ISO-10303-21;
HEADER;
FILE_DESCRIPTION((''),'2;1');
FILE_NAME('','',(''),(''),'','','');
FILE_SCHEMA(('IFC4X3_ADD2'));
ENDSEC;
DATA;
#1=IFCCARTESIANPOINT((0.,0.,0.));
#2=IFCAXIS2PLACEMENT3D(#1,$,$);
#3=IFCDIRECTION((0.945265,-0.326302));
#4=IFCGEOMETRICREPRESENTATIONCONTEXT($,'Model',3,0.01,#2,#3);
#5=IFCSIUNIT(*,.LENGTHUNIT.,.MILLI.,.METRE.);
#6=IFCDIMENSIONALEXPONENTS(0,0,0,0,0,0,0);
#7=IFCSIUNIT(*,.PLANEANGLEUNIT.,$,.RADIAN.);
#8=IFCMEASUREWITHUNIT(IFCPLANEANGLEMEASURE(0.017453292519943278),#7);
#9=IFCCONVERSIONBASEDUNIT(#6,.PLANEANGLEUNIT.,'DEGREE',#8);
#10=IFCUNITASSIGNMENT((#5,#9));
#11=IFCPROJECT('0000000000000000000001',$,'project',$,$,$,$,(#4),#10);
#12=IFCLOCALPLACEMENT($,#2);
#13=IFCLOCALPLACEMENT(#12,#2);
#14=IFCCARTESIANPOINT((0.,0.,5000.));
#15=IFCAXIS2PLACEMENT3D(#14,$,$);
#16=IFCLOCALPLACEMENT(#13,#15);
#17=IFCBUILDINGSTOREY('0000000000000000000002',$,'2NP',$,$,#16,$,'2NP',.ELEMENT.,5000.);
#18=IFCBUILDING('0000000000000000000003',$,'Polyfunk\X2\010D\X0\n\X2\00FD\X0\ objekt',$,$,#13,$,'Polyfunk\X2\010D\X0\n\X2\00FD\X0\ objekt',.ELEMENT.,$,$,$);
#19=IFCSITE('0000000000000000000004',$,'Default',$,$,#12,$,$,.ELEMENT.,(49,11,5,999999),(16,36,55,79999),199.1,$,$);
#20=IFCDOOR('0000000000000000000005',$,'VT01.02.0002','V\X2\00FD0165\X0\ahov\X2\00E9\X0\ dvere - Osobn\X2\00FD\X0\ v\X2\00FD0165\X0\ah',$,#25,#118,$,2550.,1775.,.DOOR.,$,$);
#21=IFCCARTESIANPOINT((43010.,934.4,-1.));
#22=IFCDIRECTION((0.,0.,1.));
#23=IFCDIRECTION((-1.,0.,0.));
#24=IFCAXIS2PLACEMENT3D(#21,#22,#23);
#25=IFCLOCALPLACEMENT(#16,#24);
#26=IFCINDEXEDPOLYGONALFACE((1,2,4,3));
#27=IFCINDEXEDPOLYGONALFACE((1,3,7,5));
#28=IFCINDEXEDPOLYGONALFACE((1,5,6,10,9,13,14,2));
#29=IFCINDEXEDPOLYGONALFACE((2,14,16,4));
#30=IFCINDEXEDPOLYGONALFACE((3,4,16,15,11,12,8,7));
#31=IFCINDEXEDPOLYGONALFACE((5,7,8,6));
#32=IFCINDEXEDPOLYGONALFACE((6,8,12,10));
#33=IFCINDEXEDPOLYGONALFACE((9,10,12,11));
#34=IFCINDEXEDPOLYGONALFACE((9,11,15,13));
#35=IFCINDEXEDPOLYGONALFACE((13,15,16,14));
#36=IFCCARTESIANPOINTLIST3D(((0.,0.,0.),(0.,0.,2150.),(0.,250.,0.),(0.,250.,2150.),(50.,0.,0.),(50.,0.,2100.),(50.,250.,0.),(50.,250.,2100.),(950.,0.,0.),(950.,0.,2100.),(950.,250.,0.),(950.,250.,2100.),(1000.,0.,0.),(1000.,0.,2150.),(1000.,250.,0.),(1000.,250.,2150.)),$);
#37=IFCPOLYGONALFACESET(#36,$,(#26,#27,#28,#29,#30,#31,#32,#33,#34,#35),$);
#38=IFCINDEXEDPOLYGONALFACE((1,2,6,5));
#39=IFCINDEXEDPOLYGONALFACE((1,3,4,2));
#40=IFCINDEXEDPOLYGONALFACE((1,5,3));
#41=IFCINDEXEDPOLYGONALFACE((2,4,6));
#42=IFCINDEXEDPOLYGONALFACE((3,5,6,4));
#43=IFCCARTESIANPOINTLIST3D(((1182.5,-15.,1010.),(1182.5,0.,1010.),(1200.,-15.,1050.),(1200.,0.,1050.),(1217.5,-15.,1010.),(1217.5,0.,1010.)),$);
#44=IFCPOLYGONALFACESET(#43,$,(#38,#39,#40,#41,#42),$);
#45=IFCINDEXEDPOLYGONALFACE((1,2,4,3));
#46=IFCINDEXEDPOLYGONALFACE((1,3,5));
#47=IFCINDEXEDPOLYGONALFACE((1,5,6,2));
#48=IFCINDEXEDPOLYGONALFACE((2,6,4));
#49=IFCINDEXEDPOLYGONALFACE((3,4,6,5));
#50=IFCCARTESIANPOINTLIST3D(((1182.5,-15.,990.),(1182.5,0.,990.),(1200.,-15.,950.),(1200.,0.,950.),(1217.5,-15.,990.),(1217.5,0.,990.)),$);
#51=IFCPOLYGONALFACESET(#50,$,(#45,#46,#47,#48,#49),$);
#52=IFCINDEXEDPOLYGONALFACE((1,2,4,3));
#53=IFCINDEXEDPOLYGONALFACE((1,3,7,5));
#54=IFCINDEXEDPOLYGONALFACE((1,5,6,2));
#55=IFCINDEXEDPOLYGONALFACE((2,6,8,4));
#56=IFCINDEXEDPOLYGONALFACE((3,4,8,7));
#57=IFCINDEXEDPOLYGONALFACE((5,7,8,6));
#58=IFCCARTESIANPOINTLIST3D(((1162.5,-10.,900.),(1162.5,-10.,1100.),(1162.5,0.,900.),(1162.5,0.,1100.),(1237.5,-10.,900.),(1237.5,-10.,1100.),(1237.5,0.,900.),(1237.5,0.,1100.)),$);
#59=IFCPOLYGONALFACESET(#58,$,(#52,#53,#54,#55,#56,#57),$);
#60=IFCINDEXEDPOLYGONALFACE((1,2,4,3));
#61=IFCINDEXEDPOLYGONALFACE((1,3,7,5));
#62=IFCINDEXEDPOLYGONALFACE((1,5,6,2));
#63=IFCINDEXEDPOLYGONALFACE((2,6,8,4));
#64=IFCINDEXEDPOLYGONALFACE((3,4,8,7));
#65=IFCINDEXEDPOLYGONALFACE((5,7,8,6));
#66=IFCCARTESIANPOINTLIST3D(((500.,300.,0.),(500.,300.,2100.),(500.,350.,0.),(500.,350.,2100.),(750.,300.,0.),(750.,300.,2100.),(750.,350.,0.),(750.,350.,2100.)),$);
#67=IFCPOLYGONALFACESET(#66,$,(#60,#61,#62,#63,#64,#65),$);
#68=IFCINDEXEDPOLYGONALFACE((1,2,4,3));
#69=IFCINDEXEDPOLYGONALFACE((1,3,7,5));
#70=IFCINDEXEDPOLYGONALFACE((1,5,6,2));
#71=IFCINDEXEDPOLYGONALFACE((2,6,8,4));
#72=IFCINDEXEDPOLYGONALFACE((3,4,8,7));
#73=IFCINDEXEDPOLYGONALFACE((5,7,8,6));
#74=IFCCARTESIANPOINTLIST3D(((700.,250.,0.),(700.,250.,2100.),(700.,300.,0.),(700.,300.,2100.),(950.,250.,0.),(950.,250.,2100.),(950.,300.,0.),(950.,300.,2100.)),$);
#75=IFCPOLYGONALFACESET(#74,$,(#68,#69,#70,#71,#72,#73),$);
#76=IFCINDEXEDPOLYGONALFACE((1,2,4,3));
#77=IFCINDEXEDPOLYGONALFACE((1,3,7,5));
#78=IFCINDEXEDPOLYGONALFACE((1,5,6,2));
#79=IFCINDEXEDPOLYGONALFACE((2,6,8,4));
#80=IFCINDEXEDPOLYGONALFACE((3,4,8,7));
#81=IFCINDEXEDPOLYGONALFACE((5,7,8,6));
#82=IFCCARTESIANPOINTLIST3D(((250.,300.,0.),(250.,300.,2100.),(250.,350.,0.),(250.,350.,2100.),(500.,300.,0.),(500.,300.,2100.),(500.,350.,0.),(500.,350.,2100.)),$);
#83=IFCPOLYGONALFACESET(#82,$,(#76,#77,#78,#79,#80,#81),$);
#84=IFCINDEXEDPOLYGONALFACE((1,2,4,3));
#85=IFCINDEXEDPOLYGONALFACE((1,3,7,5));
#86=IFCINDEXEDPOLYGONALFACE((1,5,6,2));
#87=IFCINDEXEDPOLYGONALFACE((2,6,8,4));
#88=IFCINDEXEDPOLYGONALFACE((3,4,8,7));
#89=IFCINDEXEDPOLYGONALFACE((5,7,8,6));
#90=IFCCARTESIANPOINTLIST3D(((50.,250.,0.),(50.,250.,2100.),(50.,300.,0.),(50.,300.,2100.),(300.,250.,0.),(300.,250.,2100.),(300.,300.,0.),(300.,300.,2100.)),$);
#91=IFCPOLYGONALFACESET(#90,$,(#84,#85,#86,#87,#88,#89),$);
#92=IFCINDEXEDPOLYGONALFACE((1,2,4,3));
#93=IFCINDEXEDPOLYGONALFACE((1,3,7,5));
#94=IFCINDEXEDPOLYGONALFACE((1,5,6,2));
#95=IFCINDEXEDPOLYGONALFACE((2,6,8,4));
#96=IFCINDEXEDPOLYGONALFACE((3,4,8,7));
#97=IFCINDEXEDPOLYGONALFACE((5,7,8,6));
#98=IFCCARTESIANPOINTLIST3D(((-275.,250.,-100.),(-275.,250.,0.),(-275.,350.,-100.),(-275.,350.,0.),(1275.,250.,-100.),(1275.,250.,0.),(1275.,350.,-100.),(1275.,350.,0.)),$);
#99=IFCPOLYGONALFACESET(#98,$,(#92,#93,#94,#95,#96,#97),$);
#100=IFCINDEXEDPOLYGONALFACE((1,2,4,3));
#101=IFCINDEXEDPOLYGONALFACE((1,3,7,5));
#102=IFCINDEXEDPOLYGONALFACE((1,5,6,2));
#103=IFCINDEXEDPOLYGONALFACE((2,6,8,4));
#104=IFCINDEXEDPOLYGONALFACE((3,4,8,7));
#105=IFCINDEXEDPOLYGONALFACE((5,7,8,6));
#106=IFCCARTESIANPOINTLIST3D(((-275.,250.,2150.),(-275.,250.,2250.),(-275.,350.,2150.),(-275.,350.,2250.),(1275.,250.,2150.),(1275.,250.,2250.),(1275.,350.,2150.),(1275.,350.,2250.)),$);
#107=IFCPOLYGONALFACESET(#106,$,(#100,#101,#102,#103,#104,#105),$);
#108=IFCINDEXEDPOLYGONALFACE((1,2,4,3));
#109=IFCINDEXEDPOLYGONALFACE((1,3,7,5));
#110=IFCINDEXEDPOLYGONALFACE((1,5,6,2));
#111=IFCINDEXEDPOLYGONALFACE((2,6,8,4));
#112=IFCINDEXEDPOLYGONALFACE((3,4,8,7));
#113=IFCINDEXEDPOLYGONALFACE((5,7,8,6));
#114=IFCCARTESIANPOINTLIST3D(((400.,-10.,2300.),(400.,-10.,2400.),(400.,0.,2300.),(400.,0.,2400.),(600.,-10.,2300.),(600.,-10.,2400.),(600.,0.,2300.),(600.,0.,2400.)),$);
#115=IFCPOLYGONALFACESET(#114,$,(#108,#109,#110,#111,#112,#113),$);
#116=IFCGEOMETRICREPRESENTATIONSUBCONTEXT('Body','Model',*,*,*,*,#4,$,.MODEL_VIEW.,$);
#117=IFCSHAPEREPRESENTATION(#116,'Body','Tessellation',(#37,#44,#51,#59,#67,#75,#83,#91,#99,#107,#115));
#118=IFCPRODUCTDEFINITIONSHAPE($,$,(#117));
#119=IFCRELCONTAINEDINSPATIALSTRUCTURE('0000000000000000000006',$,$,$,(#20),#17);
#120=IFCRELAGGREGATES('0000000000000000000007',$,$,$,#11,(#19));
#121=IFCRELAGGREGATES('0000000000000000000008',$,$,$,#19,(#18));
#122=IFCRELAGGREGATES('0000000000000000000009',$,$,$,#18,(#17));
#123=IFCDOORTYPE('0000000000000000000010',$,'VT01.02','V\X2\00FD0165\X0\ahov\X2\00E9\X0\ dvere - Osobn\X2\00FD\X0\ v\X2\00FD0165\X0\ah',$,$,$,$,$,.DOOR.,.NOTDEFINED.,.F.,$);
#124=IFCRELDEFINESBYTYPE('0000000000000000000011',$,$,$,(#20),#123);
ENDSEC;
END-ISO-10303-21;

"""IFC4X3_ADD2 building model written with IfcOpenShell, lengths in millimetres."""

from ifc_helpers import new_model, entity, si_unit, converted_unit, direction, frame, frame_2d, origin, origin_2d_with_axis, place, context, subcontext, project, spatial, polyline, rectangle, outline, extrude, source, transform, mapped, type_object, type_shapes, element, save


model = new_model("IFC4X3_ADD2")

# Units and contexts
model_context = context("Model", 3, precision=0.01, world=origin(), true_north=direction((0.945265, -0.326302)))
body_context = subcontext(model_context, "Body", "Model", "MODEL_VIEW")
ifc_project = project(units=[si_unit("LENGTHUNIT", "METRE", prefix="MILLI"), converted_unit("PLANEANGLEUNIT", "DEGREE", entity("IfcPlaneAngleMeasure", 0.017453292519943278), si_unit("PLANEANGLEUNIT", "RADIAN"), dimensions=[0, 0, 0, 0, 0, 0, 0])], contexts=[model_context])

# Site, building, storey
site_placement = place(None, origin())
site = spatial("IfcSite", under=ifc_project, at=site_placement, Name="Default", CompositionType="ELEMENT", RefLatitude=(49, 11, 5, 999999), RefLongitude=(16, 36, 55, 79999), RefElevation=199.1)
building_placement = place(site_placement, origin())
building = spatial("IfcBuilding", under=site, at=building_placement, Name="Polyfunkčný objekt", LongName="Polyfunkčný objekt", CompositionType="ELEMENT")
storey_placement = place(building_placement, frame((0.0, 0.0, 5000.0)))
storey = spatial("IfcBuildingStorey", under=building, at=storey_placement, Name="2NP", LongName="2NP", CompositionType="ELEMENT", Elevation=5000.0)

# Door
door_type = type_object("IfcDoorType", Name="VT01.02", Description="Výťahové dvere - Osobný výťah", OperationType="NOTDEFINED", ParameterTakesPrecedence=False, PredefinedType="DOOR")
shared_shape_1 = source(origin(), body_context, "Body", "SweptSolid", [
    extrude(outline(polyline([(-1087.5, -500.0), (1062.5, -500.0), (1062.5, -450.0), (-1037.5, -450.0), (-1037.5, 450.0), (1062.5, 450.0), (1062.5, 500.0), (-1087.5, 500.0), (-1087.5, -500.0)])), frame((500.0, 0.0, 1062.5), z_axis=(0.0, 1.0, 0.0), x_axis=(0.0, 0.0, -1.0)), (0.0, 0.0, 1.0), 250.0),
    extrude(outline(polyline([(-24.4, -10.7), (19.2, -10.7), (5.2, 21.4), (-24.4, -10.7)])), frame((1200.0, -15.0, 1023.3), z_axis=(0.0, 1.0, 0.0), x_axis=(0.400819, 0.0, -0.916157)), (0.0, 0.0, 1.0), 15.0),
    extrude(outline(polyline([(-24.4, -10.7), (19.2, -10.7), (5.2, 21.4), (-24.4, -10.7)])), frame((1200.0, -15.0, 976.7), z_axis=(0.0, 1.0, 0.0), x_axis=(-0.400819, 0.0, 0.916157)), (0.0, 0.0, 1.0), 15.0),
    extrude(rectangle(XDim=10.0, YDim=75.0, at=frame_2d((0.0, 0.0), x_axis=(1.0, 0.0))), frame((1200.0, -5.0, 900.0), z_axis=(0.0, 0.0, 1.0), x_axis=(0.0, 1.0, 0.0)), (0.0, 0.0, 1.0), 200.0),
    extrude(rectangle(XDim=50.0, YDim=250.0, at=origin_2d_with_axis()), frame((625.0, 325.0, 0.0), z_axis=(0.0, 0.0, 1.0), x_axis=(0.0, -1.0, 0.0)), (0.0, 0.0, 1.0), 2100.0),
    extrude(rectangle(XDim=50.0, YDim=250.0, at=frame_2d((0.0, 0.0), x_axis=(1.0, 0.0))), frame((825.0, 275.0, 0.0), z_axis=(0.0, 0.0, 1.0), x_axis=(0.0, -1.0, 0.0)), (0.0, 0.0, 1.0), 2100.0),
    extrude(rectangle(XDim=250.0, YDim=50.0, at=frame_2d((0.0, 0.0), x_axis=(1.0, 0.0))), frame((375.0, 325.0, 0.0), z_axis=(0.0, 0.0, 1.0), x_axis=(-1.0, 0.0, 0.0)), (0.0, 0.0, 1.0), 2100.0),
    extrude(rectangle(XDim=250.0, YDim=50.0, at=frame_2d((0.0, 0.0), x_axis=(1.0, 0.0))), frame((175.0, 275.0, 0.0), z_axis=(0.0, 0.0, 1.0), x_axis=(-1.0, 0.0, 0.0)), (0.0, 0.0, 1.0), 2100.0),
    extrude(rectangle(XDim=1550.0, YDim=100.0, at=frame_2d((0.0, 0.0), x_axis=(1.0, 0.0))), frame((500.0, 300.0, -100.0), z_axis=(0.0, 0.0, 1.0), x_axis=(-1.0, 0.0, 0.0)), (0.0, 0.0, 1.0), 100.0),
    extrude(rectangle(XDim=1550.0, YDim=100.0, at=frame_2d((0.0, 0.0), x_axis=(1.0, 0.0))), frame((500.0, 300.0, 2150.0), z_axis=(0.0, 0.0, 1.0), x_axis=(-1.0, 0.0, 0.0)), (0.0, 0.0, 1.0), 100.0),
    extrude(rectangle(XDim=10.0, YDim=200.0, at=frame_2d((0.0, 0.0), x_axis=(1.0, 0.0))), frame((500.0, -5.0, 2300.0), z_axis=(0.0, 0.0, 1.0), x_axis=(0.0, 1.0, 0.0)), (0.0, 0.0, 1.0), 100.0),
])
type_shapes(door_type, [shared_shape_1])
door_placement = place(storey_placement, frame((43010.0, 934.4, -1.0), z_axis=(0.0, 0.0, 1.0), x_axis=(-1.0, 0.0, 0.0)))
element("IfcDoor", 1, at=door_placement, inside=storey, type_object=door_type, Name="VT01.02.0002", Description="Výťahové dvere - Osobný výťah", OverallHeight=2550.0, OverallWidth=1775.0, PredefinedType="DOOR", context=body_context, shape_type="MappedRepresentation", body=[
    mapped(shared_shape_1, transform((0.0, 0.0, 0.0), scale=1.0)),
])

save(model, "model.ifc")
